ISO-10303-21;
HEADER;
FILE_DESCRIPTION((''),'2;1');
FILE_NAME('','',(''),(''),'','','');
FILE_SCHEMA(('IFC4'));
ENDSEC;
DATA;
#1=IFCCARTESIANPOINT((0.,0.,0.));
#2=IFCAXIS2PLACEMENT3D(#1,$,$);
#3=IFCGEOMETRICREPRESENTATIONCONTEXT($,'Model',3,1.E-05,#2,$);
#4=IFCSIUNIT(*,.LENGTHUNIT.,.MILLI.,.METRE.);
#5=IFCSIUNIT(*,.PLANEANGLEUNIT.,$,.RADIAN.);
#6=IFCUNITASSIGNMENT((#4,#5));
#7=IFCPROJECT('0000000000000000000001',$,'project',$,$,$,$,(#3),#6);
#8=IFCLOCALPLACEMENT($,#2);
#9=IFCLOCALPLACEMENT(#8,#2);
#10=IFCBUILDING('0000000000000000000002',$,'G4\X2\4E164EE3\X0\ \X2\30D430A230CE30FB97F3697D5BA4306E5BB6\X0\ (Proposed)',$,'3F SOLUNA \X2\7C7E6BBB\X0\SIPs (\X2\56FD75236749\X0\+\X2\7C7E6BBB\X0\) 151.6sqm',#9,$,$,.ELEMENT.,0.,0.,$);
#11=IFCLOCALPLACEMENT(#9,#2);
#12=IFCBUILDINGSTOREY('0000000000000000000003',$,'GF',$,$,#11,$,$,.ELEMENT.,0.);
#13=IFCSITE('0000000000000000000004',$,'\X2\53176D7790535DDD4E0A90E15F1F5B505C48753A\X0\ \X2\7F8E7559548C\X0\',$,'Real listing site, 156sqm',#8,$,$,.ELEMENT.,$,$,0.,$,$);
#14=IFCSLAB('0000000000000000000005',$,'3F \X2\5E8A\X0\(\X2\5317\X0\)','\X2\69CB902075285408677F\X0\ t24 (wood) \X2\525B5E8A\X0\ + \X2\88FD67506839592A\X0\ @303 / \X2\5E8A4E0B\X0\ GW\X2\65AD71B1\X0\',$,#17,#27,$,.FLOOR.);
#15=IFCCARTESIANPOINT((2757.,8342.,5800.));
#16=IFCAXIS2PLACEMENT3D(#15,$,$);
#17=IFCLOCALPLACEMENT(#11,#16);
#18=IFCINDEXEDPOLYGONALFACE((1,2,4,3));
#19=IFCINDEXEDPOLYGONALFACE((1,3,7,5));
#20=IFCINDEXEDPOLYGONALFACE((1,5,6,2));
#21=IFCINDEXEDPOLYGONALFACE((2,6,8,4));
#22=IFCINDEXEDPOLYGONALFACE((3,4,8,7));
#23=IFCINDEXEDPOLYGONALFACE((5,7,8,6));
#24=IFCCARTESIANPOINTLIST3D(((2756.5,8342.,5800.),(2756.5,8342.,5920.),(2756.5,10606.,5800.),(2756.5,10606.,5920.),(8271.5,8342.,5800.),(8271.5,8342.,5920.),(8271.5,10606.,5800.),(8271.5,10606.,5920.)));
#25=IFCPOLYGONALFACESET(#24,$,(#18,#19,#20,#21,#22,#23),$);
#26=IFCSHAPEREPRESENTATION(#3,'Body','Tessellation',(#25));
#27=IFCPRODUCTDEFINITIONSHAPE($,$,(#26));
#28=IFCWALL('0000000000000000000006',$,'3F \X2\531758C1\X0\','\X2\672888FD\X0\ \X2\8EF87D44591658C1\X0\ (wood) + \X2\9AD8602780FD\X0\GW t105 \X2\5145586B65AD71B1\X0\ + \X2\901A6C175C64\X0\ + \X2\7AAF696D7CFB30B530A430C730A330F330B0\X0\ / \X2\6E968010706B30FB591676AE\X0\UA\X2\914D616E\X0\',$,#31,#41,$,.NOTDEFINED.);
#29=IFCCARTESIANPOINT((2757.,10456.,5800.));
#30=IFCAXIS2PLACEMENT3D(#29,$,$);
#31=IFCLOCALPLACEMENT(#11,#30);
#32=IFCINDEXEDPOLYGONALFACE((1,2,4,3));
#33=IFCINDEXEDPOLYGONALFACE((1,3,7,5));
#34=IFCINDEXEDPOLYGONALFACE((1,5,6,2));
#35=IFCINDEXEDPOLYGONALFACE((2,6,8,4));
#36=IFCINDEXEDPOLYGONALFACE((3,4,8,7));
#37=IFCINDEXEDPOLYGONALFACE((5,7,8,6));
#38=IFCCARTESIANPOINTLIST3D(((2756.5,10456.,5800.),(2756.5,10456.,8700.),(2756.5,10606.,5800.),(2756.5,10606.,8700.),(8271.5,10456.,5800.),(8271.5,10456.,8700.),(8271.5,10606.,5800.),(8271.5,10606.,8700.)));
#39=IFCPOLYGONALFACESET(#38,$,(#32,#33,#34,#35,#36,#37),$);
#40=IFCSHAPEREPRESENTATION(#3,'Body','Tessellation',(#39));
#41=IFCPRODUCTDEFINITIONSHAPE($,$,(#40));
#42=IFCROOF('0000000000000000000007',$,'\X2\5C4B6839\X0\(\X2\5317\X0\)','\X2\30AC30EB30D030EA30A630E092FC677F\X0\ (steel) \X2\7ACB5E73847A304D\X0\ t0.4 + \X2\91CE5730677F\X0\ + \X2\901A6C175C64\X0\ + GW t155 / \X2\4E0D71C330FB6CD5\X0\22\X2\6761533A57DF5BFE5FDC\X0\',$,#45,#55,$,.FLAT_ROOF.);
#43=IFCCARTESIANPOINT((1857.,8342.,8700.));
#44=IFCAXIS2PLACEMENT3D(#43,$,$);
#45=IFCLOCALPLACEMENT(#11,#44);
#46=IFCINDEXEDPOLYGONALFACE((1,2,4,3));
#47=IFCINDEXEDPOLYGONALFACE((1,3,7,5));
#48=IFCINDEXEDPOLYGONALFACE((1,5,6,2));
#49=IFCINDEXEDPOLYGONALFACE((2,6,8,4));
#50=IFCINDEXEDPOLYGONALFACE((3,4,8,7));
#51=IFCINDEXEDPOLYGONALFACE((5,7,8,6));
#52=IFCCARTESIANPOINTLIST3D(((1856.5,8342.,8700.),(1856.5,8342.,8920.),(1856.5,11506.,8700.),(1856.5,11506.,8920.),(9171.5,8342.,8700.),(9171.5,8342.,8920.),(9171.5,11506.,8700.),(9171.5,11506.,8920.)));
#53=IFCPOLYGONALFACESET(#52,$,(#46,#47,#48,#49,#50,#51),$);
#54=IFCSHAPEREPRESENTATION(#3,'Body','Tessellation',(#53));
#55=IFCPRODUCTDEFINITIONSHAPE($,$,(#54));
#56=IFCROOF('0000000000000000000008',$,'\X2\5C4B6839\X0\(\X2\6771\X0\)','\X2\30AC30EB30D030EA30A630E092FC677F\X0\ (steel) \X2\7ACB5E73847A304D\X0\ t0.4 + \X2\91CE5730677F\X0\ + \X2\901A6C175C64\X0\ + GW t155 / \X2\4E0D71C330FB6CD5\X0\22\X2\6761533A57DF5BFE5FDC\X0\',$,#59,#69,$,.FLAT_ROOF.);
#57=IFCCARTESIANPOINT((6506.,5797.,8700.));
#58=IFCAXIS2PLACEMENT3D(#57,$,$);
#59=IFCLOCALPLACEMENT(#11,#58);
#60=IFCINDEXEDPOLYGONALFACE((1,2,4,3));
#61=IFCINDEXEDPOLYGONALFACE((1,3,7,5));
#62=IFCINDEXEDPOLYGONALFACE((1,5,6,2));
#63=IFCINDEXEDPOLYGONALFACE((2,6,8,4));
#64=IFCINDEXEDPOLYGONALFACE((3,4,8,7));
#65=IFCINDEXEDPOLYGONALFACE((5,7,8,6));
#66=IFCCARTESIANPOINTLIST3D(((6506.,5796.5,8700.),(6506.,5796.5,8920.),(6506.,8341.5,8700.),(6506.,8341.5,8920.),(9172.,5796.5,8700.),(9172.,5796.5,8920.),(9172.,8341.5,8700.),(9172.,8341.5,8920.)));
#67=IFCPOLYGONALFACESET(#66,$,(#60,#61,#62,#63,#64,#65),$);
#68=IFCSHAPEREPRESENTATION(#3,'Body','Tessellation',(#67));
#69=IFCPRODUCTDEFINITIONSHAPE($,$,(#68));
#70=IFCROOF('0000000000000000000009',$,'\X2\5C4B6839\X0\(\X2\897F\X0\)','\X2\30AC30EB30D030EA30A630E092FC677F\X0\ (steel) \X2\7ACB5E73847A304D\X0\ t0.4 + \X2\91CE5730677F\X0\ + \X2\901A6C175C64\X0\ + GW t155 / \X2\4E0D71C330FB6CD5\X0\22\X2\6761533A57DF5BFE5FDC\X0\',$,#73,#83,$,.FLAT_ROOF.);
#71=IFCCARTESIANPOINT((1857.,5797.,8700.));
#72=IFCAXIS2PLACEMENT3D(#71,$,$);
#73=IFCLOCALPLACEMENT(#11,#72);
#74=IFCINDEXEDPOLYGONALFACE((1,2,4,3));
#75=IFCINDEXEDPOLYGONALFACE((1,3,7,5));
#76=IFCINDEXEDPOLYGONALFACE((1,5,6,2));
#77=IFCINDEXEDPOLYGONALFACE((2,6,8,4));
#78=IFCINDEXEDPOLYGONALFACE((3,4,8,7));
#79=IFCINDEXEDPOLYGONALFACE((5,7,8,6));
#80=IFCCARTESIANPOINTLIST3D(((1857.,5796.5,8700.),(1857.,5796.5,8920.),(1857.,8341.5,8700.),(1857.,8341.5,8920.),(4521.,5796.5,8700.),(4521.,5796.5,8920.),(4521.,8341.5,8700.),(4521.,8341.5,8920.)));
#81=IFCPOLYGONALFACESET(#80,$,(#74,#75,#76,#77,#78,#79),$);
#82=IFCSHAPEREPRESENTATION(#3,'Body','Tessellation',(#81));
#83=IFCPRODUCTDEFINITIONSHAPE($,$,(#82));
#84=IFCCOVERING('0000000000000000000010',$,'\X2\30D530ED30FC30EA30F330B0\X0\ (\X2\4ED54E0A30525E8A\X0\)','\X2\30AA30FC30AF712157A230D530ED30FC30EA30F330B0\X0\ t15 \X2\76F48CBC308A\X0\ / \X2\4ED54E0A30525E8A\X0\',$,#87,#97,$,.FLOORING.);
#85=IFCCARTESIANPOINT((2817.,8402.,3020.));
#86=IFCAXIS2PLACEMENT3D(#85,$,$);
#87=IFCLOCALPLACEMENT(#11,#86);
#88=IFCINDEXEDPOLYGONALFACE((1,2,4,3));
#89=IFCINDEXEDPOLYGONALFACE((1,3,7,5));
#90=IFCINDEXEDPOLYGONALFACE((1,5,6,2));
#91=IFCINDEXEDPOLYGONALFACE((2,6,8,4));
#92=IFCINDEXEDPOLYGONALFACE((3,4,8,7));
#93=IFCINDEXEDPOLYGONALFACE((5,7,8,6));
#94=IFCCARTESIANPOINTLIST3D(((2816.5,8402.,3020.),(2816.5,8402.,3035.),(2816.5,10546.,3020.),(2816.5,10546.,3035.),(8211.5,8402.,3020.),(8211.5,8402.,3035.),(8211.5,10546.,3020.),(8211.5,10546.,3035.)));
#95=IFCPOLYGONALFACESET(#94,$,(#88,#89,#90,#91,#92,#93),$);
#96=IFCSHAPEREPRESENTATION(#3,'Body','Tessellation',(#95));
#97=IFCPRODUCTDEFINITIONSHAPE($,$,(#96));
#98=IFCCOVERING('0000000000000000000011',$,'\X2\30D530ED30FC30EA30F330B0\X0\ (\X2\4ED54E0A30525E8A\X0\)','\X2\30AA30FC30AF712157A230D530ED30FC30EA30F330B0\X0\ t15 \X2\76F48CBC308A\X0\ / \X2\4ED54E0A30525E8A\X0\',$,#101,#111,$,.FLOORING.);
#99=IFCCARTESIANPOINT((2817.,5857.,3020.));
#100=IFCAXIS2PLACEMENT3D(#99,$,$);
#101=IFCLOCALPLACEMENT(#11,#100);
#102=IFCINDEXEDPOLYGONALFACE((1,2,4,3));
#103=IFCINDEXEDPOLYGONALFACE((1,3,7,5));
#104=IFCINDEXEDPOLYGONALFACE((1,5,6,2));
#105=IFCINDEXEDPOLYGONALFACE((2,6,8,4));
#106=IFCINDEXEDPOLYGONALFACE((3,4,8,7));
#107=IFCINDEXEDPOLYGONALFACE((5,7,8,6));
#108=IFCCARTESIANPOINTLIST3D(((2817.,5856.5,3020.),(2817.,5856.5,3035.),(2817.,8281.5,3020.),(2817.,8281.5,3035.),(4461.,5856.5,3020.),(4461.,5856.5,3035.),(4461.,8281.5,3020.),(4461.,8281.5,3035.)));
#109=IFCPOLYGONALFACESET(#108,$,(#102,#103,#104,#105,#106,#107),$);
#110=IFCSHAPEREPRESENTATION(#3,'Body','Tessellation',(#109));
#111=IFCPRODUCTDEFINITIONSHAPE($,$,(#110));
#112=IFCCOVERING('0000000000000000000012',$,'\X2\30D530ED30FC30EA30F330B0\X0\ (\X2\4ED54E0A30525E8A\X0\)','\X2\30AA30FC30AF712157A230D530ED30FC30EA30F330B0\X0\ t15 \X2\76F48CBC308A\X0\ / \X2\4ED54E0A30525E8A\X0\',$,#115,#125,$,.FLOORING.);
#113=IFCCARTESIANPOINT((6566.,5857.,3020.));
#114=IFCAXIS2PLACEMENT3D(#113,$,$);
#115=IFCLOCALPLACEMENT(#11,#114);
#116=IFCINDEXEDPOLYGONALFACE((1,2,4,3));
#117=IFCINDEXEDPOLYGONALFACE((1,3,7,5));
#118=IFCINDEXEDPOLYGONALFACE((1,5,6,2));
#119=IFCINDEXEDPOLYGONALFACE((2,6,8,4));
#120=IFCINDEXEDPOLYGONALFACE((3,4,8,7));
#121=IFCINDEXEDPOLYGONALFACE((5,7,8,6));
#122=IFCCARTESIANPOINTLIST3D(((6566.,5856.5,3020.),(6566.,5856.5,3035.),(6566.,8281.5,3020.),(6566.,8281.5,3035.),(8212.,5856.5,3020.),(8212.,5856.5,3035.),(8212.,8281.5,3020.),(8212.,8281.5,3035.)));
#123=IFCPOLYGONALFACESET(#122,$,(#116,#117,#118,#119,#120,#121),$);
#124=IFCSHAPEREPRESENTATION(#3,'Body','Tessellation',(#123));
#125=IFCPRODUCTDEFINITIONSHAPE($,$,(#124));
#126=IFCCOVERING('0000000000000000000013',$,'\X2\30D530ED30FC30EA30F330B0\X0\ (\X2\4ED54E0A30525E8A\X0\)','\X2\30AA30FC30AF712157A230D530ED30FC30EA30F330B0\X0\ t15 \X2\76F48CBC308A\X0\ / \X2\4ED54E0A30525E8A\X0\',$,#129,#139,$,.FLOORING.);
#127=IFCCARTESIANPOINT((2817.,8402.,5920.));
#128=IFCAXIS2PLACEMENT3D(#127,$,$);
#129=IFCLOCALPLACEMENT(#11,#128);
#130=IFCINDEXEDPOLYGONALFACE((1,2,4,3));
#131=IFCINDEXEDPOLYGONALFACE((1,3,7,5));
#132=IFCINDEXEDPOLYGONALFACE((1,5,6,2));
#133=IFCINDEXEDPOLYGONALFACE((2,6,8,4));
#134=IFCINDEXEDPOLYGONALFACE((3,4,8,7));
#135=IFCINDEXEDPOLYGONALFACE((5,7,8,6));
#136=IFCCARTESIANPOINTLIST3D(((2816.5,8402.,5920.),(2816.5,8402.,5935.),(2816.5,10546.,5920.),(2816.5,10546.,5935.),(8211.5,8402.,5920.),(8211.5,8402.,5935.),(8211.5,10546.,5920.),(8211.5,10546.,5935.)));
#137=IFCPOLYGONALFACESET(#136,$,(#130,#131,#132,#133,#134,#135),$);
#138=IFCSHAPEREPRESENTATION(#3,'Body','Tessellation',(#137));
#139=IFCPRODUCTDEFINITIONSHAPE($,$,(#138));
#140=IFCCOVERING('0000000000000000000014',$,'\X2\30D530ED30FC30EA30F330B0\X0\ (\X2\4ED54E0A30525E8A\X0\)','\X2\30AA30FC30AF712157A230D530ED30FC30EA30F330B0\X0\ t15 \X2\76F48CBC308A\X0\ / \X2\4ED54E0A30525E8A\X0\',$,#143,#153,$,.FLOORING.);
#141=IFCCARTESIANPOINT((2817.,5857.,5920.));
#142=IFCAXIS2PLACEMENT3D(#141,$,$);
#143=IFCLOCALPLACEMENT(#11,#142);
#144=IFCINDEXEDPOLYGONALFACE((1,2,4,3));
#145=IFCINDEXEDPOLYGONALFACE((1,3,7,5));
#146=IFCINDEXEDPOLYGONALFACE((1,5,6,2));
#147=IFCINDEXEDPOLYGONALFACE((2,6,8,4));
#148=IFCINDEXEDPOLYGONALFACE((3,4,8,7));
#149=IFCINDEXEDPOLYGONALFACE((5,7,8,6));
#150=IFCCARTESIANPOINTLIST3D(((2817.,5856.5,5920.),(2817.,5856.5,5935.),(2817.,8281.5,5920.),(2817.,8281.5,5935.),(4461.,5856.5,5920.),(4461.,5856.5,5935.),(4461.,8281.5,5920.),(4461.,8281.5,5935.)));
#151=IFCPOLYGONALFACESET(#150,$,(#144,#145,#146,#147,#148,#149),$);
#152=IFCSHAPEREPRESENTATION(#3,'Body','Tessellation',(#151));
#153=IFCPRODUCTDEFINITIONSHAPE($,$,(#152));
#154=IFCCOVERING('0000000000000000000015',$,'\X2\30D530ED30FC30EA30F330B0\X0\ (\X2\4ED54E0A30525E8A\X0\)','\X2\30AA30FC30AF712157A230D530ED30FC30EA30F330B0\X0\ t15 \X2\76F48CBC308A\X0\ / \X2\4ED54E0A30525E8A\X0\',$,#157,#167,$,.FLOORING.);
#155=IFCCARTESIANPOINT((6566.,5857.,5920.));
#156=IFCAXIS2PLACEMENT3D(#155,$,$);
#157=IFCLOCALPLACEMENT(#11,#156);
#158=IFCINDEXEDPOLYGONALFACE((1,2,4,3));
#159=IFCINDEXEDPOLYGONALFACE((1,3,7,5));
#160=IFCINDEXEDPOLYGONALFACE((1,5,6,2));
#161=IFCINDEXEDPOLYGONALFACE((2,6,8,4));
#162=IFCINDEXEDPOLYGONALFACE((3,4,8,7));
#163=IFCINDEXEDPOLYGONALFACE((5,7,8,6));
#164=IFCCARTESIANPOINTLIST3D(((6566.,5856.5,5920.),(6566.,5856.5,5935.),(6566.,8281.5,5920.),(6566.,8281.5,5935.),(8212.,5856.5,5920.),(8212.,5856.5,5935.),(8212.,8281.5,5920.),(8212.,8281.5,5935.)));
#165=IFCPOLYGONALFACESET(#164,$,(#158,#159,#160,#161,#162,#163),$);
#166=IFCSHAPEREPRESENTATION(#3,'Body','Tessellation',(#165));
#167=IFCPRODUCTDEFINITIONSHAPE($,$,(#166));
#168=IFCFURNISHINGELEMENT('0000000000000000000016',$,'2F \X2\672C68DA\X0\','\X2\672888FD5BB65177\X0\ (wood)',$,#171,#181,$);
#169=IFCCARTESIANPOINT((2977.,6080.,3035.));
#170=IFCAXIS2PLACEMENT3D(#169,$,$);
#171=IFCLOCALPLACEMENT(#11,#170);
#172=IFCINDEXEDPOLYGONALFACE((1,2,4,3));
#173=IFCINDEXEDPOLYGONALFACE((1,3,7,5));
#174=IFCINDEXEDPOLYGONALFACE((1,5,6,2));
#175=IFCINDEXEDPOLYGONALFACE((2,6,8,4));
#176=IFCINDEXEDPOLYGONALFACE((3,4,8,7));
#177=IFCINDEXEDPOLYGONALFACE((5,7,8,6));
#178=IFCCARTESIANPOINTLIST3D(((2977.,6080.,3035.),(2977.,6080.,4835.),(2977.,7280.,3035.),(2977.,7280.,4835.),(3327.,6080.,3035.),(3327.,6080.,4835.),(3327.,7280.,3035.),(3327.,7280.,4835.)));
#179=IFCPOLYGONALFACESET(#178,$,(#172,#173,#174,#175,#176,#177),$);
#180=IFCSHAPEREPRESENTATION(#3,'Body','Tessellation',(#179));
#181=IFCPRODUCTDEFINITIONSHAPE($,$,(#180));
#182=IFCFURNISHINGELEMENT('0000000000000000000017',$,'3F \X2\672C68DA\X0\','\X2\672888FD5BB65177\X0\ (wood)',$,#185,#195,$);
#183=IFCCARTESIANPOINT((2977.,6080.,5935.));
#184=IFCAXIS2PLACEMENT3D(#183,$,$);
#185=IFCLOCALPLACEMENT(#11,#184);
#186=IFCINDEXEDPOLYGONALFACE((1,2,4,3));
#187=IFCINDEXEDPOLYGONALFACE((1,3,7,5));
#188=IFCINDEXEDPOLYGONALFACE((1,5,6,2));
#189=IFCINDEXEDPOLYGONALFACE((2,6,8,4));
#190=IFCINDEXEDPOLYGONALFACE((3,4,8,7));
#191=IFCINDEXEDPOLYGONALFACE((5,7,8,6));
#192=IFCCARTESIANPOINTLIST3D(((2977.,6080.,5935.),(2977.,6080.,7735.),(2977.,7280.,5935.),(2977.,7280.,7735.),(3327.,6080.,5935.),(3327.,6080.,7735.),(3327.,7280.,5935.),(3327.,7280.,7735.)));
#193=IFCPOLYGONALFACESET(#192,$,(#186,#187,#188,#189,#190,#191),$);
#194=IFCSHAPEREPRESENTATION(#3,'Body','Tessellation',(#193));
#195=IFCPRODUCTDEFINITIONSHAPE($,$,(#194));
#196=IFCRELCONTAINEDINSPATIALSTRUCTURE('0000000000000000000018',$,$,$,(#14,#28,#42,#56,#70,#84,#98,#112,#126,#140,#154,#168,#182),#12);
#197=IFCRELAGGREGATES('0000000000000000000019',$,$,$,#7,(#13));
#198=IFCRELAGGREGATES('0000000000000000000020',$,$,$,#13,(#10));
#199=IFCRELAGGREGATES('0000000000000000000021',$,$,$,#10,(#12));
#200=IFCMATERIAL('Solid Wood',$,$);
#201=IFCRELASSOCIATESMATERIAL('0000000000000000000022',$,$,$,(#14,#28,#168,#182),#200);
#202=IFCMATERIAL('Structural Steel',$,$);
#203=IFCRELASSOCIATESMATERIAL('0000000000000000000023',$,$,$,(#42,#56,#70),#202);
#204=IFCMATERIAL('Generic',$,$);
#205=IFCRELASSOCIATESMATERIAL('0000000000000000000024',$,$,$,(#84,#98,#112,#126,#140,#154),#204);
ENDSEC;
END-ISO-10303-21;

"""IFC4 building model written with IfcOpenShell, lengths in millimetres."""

from ifc_helpers import new_model, si_unit, frame, frame_2d, origin, place, context, project, spatial, rectangle, extrude, material, element, save


model = new_model("IFC4")

# Units and contexts
model_context = context("Model", 3, precision=1e-05, world=origin())
ifc_project = project(units=[si_unit("LENGTHUNIT", "METRE", prefix="MILLI"), si_unit("PLANEANGLEUNIT", "RADIAN")], contexts=[model_context])

# Site, building, storey
site_placement = place(None, origin())
site = spatial("IfcSite", under=ifc_project, at=site_placement, Name="北海道川上郡弟子屈町 美留和", ObjectType="Real listing site, 156sqm", CompositionType="ELEMENT", RefElevation=0.0)
building_placement = place(site_placement, origin())
building = spatial("IfcBuilding", under=site, at=building_placement, Name="G4世代 ピアノ・音楽室の家 (Proposed)", ObjectType="3F SOLUNA 籾殻SIPs (国産杉+籾殻) 151.6sqm", CompositionType="ELEMENT", ElevationOfRefHeight=0.0, ElevationOfTerrain=0.0)
storey_placement = place(building_placement, origin())
storey = spatial("IfcBuildingStorey", under=building, at=storey_placement, Name="GF", CompositionType="ELEMENT", Elevation=0.0)

# Slab
ifc_material_1 = material(Name="Solid Wood")
slab_placement = place(storey_placement, frame((2757.0, 8342.0, 5800.0)))
element("IfcSlab", 1, at=slab_placement, inside=storey, material=ifc_material_1, Name="3F 床(北)", Description="構造用合板 t24 (wood) 剛床 + 製材根太 @303 / 床下 GW断熱", PredefinedType="FLOOR", context=model_context, shape_type="SweptSolid", body=[
    extrude(rectangle(XDim=5515.0, YDim=2264.0, at=frame_2d((2757.0, 1132.0))), frame((2757.0, 8342.0, 5800.0)), (0.0, 0.0, 1.0), 120.0),
])

# Wall
wall_1_placement = place(storey_placement, frame((2757.0, 10456.0, 5800.0)))
element("IfcWall", 2, at=wall_1_placement, inside=storey, material=ifc_material_1, Name="3F 北壁", Description="木製 軸組外壁 (wood) + 高性能GW t105 充填断熱 + 通気層 + 窯業系サイディング / 準耐火・外皮UA配慮", PredefinedType="NOTDEFINED", context=model_context, shape_type="SweptSolid", body=[
    extrude(rectangle(XDim=5515.0, YDim=150.0, at=frame_2d((2757.0, 75.0))), frame((2757.0, 10456.0, 5800.0)), (0.0, 0.0, 1.0), 2900.0),
])

# Shared definitions
ifc_material_2 = material(Name="Generic")

# Roofs
ifc_material_3 = material(Name="Structural Steel")
roof_1_placement = place(storey_placement, frame((1857.0, 8342.0, 8700.0)))
element("IfcRoof", 3, at=roof_1_placement, inside=storey, material=ifc_material_3, Name="屋根(北)", Description="ガルバリウム鋼板 (steel) 立平葺き t0.4 + 野地板 + 通気層 + GW t155 / 不燃・法22条区域対応", PredefinedType="FLAT_ROOF", context=model_context, shape_type="SweptSolid", body=[
    extrude(rectangle(XDim=7315.0, YDim=3164.0, at=frame_2d((3657.0, 1582.0))), frame((1857.0, 8342.0, 8700.0)), (0.0, 0.0, 1.0), 220.0),
])
roof_2_placement = place(storey_placement, frame((6506.0, 5797.0, 8700.0)))
element("IfcRoof", 4, at=roof_2_placement, inside=storey, material=ifc_material_3, Name="屋根(東)", Description="ガルバリウム鋼板 (steel) 立平葺き t0.4 + 野地板 + 通気層 + GW t155 / 不燃・法22条区域対応", PredefinedType="FLAT_ROOF", context=model_context, shape_type="SweptSolid", body=[
    extrude(rectangle(XDim=2666.0, YDim=2545.0, at=frame_2d((1333.0, 1272.0))), frame((6506.0, 5797.0, 8700.0)), (0.0, 0.0, 1.0), 220.0),
])
roof_3_placement = place(storey_placement, frame((1857.0, 5797.0, 8700.0)))
element("IfcRoof", 5, at=roof_3_placement, inside=storey, material=ifc_material_3, Name="屋根(西)", Description="ガルバリウム鋼板 (steel) 立平葺き t0.4 + 野地板 + 通気層 + GW t155 / 不燃・法22条区域対応", PredefinedType="FLAT_ROOF", context=model_context, shape_type="SweptSolid", body=[
    extrude(rectangle(XDim=2664.0, YDim=2545.0, at=frame_2d((1332.0, 1272.0))), frame((1857.0, 5797.0, 8700.0)), (0.0, 0.0, 1.0), 220.0),
])

# Coverings
covering_1_placement = place(storey_placement, frame((2817.0, 8402.0, 3020.0)))
element("IfcCovering", 6, at=covering_1_placement, inside=storey, material=ifc_material_2, Name="フローリング (仕上げ床)", Description="オーク無垢フローリング t15 直貼り / 仕上げ床", PredefinedType="FLOORING", context=model_context, shape_type="SweptSolid", body=[
    extrude(rectangle(XDim=5395.0, YDim=2144.0, at=frame_2d((2697.0, 1072.0))), frame((2817.0, 8402.0, 3020.0)), (0.0, 0.0, 1.0), 15.0),
])
covering_2_placement = place(storey_placement, frame((2817.0, 5857.0, 3020.0)))
element("IfcCovering", 7, at=covering_2_placement, inside=storey, material=ifc_material_2, Name="フローリング (仕上げ床)", Description="オーク無垢フローリング t15 直貼り / 仕上げ床", PredefinedType="FLOORING", context=model_context, shape_type="SweptSolid", body=[
    extrude(rectangle(XDim=1644.0, YDim=2425.0, at=frame_2d((822.0, 1212.0))), frame((2817.0, 5857.0, 3020.0)), (0.0, 0.0, 1.0), 15.0),
])
covering_3_placement = place(storey_placement, frame((6566.0, 5857.0, 3020.0)))
element("IfcCovering", 8, at=covering_3_placement, inside=storey, material=ifc_material_2, Name="フローリング (仕上げ床)", Description="オーク無垢フローリング t15 直貼り / 仕上げ床", PredefinedType="FLOORING", context=model_context, shape_type="SweptSolid", body=[
    extrude(rectangle(XDim=1646.0, YDim=2425.0, at=frame_2d((823.0, 1212.0))), frame((6566.0, 5857.0, 3020.0)), (0.0, 0.0, 1.0), 15.0),
])
covering_4_placement = place(storey_placement, frame((2817.0, 8402.0, 5920.0)))
element("IfcCovering", 9, at=covering_4_placement, inside=storey, material=ifc_material_2, Name="フローリング (仕上げ床)", Description="オーク無垢フローリング t15 直貼り / 仕上げ床", PredefinedType="FLOORING", context=model_context, shape_type="SweptSolid", body=[
    extrude(rectangle(XDim=5395.0, YDim=2144.0, at=frame_2d((2697.0, 1072.0))), frame((2817.0, 8402.0, 5920.0)), (0.0, 0.0, 1.0), 15.0),
])
covering_5_placement = place(storey_placement, frame((2817.0, 5857.0, 5920.0)))
element("IfcCovering", 10, at=covering_5_placement, inside=storey, material=ifc_material_2, Name="フローリング (仕上げ床)", Description="オーク無垢フローリング t15 直貼り / 仕上げ床", PredefinedType="FLOORING", context=model_context, shape_type="SweptSolid", body=[
    extrude(rectangle(XDim=1644.0, YDim=2425.0, at=frame_2d((822.0, 1212.0))), frame((2817.0, 5857.0, 5920.0)), (0.0, 0.0, 1.0), 15.0),
])
covering_6_placement = place(storey_placement, frame((6566.0, 5857.0, 5920.0)))
element("IfcCovering", 11, at=covering_6_placement, inside=storey, material=ifc_material_2, Name="フローリング (仕上げ床)", Description="オーク無垢フローリング t15 直貼り / 仕上げ床", PredefinedType="FLOORING", context=model_context, shape_type="SweptSolid", body=[
    extrude(rectangle(XDim=1646.0, YDim=2425.0, at=frame_2d((823.0, 1212.0))), frame((6566.0, 5857.0, 5920.0)), (0.0, 0.0, 1.0), 15.0),
])

# Furnishing elements
furnishing_1_placement = place(storey_placement, frame((2977.0, 6080.0, 3035.0)))
element("IfcFurnishingElement", 12, at=furnishing_1_placement, inside=storey, material=ifc_material_1, Name="2F 本棚", Description="木製家具 (wood)", context=model_context, shape_type="SweptSolid", body=[
    extrude(rectangle(XDim=350.0, YDim=1200.0, at=frame_2d((175.0, 600.0))), frame((2977.0, 6080.0, 3035.0)), (0.0, 0.0, 1.0), 1800.0),
])
furnishing_2_placement = place(storey_placement, frame((2977.0, 6080.0, 5935.0)))
element("IfcFurnishingElement", 13, at=furnishing_2_placement, inside=storey, material=ifc_material_1, Name="3F 本棚", Description="木製家具 (wood)", context=model_context, shape_type="SweptSolid", body=[
    extrude(rectangle(XDim=350.0, YDim=1200.0, at=frame_2d((175.0, 600.0))), frame((2977.0, 6080.0, 5935.0)), (0.0, 0.0, 1.0), 1800.0),
])

save(model, "model.ifc")
